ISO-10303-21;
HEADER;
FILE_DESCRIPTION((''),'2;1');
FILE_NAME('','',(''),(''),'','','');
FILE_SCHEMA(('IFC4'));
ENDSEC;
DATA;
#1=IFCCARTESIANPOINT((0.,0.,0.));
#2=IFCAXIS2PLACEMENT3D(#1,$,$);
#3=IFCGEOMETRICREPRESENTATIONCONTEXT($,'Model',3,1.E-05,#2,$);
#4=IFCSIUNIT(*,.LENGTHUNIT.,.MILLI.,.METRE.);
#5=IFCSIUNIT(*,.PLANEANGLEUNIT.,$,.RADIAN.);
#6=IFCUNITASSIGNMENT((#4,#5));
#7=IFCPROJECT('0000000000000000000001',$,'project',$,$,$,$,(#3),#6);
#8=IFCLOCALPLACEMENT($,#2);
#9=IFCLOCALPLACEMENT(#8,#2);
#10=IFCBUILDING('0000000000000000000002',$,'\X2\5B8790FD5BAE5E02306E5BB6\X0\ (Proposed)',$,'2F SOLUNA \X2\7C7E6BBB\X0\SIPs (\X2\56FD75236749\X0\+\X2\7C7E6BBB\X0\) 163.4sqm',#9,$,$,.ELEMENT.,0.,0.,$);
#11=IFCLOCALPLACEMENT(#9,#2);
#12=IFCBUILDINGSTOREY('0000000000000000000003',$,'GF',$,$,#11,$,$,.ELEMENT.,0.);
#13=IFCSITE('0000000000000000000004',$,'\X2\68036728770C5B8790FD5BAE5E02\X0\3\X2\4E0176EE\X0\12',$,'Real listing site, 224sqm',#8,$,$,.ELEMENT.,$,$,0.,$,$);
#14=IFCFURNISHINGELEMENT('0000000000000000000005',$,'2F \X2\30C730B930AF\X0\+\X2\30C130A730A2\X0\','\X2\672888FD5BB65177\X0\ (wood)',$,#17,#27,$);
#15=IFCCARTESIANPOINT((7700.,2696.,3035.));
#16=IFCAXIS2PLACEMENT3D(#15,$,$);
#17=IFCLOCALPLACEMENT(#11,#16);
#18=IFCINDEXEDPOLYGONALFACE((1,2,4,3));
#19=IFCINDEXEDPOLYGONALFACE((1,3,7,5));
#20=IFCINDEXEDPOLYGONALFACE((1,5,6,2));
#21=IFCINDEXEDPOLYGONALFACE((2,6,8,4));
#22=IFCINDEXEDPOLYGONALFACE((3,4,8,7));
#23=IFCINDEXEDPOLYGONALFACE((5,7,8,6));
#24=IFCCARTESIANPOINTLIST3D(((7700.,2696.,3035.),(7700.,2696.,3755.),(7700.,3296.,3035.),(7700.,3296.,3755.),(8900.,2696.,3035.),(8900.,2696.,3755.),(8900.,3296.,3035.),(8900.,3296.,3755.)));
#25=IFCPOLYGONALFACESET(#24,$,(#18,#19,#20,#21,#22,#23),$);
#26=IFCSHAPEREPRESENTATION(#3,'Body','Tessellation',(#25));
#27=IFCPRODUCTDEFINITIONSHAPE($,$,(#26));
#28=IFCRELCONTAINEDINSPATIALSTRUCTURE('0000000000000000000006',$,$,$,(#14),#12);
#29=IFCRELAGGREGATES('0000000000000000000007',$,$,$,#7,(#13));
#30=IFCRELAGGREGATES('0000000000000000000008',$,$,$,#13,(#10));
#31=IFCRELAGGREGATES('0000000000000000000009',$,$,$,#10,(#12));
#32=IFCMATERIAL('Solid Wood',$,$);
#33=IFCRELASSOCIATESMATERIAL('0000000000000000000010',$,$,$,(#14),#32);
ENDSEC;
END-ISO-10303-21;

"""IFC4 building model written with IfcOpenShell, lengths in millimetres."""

from ifc_helpers import new_model, si_unit, frame, frame_2d, origin, place, context, project, spatial, rectangle, extrude, material, element, save


model = new_model("IFC4")

# Units and contexts
model_context = context("Model", 3, precision=1e-05, world=origin())
ifc_project = project(units=[si_unit("LENGTHUNIT", "METRE", prefix="MILLI"), si_unit("PLANEANGLEUNIT", "RADIAN")], contexts=[model_context])

# Site, building, storey
site_placement = place(None, origin())
site = spatial("IfcSite", under=ifc_project, at=site_placement, Name="栃木県宇都宮市3丁目12", ObjectType="Real listing site, 224sqm", CompositionType="ELEMENT", RefElevation=0.0)
building_placement = place(site_placement, origin())
building = spatial("IfcBuilding", under=site, at=building_placement, Name="宇都宮市の家 (Proposed)", ObjectType="2F SOLUNA 籾殻SIPs (国産杉+籾殻) 163.4sqm", CompositionType="ELEMENT", ElevationOfRefHeight=0.0, ElevationOfTerrain=0.0)
storey_placement = place(building_placement, origin())
storey = spatial("IfcBuildingStorey", under=building, at=storey_placement, Name="GF", CompositionType="ELEMENT", Elevation=0.0)

# Shared definitions
ifc_material_1 = material(Name="Solid Wood")

# Furnishing element
furnishing_1_placement = place(storey_placement, frame((7700.0, 2696.0, 3035.0)))
element("IfcFurnishingElement", 1, at=furnishing_1_placement, inside=storey, material=ifc_material_1, Name="2F デスク+チェア", Description="木製家具 (wood)", context=model_context, shape_type="SweptSolid", body=[
    extrude(rectangle(XDim=1200.0, YDim=600.0, at=frame_2d((600.0, 300.0))), frame((7700.0, 2696.0, 3035.0)), (0.0, 0.0, 1.0), 720.0),
])

save(model, "model.ifc")
